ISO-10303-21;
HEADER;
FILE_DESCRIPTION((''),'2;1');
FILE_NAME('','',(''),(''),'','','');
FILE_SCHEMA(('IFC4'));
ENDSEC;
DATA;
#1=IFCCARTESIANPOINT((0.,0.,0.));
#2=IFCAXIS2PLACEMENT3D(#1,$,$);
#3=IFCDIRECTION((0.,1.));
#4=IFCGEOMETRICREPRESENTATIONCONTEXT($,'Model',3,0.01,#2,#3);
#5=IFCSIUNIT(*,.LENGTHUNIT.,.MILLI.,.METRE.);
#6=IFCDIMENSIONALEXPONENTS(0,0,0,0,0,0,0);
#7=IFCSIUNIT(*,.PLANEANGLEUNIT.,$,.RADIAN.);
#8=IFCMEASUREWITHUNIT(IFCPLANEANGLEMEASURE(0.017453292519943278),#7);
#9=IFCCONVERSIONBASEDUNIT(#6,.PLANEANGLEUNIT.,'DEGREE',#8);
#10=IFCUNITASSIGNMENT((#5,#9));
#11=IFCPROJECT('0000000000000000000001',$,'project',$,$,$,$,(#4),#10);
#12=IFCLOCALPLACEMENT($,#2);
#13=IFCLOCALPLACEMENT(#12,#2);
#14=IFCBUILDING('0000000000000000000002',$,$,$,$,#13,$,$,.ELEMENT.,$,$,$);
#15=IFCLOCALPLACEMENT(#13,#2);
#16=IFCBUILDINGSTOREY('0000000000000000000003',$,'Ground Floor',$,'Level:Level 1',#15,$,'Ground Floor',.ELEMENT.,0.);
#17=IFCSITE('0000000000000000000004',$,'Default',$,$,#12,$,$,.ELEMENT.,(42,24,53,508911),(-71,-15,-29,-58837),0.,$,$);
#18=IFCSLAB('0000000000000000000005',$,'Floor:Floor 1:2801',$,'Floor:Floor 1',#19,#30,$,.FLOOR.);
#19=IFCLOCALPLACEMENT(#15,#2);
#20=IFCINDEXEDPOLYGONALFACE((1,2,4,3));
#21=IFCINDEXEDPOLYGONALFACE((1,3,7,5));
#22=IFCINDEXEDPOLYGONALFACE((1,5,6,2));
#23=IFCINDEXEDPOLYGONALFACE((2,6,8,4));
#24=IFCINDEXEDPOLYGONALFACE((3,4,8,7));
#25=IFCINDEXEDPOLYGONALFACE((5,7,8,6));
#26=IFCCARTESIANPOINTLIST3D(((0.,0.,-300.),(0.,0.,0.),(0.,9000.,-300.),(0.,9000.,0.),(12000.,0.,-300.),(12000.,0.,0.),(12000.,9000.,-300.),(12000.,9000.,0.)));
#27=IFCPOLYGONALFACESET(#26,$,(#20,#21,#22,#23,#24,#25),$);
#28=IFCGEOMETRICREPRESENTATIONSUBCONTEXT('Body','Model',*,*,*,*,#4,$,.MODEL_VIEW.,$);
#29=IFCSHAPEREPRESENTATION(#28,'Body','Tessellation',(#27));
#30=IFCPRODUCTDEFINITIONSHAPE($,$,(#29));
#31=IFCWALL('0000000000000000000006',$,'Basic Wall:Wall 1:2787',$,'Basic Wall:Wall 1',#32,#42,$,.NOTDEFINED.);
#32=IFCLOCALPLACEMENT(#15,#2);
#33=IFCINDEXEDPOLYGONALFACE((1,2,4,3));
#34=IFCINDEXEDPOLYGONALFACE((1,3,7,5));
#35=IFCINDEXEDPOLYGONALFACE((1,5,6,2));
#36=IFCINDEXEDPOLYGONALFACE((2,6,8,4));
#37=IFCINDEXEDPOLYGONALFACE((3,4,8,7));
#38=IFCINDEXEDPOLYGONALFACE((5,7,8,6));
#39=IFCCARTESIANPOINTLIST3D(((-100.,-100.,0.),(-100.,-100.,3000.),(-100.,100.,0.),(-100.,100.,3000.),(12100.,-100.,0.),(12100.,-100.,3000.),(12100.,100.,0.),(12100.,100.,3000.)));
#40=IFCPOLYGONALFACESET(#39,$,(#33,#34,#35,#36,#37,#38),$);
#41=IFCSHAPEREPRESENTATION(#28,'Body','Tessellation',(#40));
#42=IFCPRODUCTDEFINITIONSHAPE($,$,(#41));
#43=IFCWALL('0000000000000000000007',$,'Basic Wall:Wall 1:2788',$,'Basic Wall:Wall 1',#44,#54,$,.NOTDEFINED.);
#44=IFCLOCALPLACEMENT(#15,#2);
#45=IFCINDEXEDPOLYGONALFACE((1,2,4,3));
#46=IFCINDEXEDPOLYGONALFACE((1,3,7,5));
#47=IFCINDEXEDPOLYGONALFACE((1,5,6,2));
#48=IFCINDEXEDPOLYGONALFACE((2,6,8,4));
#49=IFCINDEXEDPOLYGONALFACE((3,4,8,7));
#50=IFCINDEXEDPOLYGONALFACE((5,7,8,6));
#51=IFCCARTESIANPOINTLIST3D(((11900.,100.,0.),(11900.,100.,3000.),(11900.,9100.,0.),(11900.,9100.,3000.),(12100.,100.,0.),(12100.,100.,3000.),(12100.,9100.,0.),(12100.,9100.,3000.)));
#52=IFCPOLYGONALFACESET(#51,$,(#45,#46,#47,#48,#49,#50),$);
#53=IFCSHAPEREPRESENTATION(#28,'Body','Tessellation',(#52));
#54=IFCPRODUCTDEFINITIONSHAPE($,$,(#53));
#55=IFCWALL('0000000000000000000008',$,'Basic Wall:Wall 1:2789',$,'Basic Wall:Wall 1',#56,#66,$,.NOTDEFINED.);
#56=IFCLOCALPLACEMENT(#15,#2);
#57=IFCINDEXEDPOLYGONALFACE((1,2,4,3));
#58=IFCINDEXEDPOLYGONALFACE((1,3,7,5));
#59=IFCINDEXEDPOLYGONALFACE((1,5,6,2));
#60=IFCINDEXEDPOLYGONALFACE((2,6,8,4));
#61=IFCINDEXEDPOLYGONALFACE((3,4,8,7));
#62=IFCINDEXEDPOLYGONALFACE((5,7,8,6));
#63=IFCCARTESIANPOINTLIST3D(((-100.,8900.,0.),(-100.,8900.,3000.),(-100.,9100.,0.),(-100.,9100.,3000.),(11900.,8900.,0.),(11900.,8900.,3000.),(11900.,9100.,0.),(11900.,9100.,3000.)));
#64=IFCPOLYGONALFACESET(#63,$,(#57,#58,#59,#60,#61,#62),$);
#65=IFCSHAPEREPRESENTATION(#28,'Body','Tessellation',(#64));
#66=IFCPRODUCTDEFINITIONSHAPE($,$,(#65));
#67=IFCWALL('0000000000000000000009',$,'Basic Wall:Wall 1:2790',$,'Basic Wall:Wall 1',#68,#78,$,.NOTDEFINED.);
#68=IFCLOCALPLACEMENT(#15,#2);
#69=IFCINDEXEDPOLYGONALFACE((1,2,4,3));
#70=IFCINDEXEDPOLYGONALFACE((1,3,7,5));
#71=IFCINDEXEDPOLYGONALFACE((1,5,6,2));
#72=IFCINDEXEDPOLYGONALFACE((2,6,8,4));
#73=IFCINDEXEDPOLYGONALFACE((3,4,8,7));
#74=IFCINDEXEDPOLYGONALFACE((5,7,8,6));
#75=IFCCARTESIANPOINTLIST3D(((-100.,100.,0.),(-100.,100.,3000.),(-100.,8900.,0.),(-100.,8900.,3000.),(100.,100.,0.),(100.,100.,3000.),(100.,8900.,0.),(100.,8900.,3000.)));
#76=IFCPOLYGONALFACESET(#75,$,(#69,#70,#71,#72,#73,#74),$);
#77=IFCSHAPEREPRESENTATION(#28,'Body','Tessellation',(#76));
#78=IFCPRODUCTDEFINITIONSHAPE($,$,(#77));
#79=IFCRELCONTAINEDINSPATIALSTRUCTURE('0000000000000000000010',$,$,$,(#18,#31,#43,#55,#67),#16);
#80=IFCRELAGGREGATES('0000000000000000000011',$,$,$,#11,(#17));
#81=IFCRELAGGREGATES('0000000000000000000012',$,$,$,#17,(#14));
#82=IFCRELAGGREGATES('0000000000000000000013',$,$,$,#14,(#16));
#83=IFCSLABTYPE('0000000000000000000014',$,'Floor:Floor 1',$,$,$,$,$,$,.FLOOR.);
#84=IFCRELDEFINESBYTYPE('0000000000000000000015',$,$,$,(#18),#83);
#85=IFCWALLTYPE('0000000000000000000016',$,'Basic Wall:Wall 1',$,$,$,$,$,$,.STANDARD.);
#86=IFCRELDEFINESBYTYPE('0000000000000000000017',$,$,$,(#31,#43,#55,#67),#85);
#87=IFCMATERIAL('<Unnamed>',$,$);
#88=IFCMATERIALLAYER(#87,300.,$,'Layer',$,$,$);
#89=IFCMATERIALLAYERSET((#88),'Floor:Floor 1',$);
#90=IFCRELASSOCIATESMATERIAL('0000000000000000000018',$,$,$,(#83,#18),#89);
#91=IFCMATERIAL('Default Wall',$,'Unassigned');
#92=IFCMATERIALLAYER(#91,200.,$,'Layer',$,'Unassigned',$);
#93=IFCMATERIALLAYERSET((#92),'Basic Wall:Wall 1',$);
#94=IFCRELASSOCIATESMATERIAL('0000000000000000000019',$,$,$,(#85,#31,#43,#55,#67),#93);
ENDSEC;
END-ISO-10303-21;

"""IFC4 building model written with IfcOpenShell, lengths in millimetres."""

from ifc_helpers import new_model, entity, si_unit, converted_unit, direction, frame, frame_2d, origin, origin_2d_with_axis, place, context, subcontext, project, spatial, rectangle, extrude, material, layer, layer_set, layer_usage, type_object, element, save


model = new_model("IFC4")

# Units and contexts
model_context = context("Model", 3, precision=0.01, world=origin(), true_north=direction((0.0, 1.0)))
body_context = subcontext(model_context, "Body", "Model", "MODEL_VIEW")
ifc_project = project(units=[si_unit("LENGTHUNIT", "METRE", prefix="MILLI"), converted_unit("PLANEANGLEUNIT", "DEGREE", entity("IfcPlaneAngleMeasure", 0.017453292519943278), si_unit("PLANEANGLEUNIT", "RADIAN"), dimensions=[0, 0, 0, 0, 0, 0, 0])], contexts=[model_context])

# Site, building, storey
site_placement = place(None, origin())
site = spatial("IfcSite", under=ifc_project, at=site_placement, Name="Default", CompositionType="ELEMENT", RefLatitude=(42, 24, 53, 508911), RefLongitude=(-71, -15, -29, -58837), RefElevation=0.0)
building_placement = place(site_placement, origin())
building = spatial("IfcBuilding", under=site, at=building_placement, CompositionType="ELEMENT")
storey_placement = place(building_placement, origin())
storey = spatial("IfcBuildingStorey", under=building, at=storey_placement, Name="Ground Floor", ObjectType="Level:Level 1", LongName="Ground Floor", CompositionType="ELEMENT", Elevation=0.0)

# Slab
ifc_material_1 = material(Name="<Unnamed>")
ifc_layer_1 = layer(ifc_material_1, 300.0, Name="Layer")
ifc_layer_set_1 = layer_set([ifc_layer_1], Name="Floor:Floor 1")
ifc_layer_usage_1 = layer_usage(ifc_layer_set_1, "AXIS3", "POSITIVE", 0.0)
slab_type = type_object("IfcSlabType", Name="Floor:Floor 1", PredefinedType="FLOOR", material=ifc_layer_set_1)
slab_placement = place(storey_placement, origin())
element("IfcSlab", 1, at=slab_placement, inside=storey, type_object=slab_type, material=ifc_layer_usage_1, Name="Floor:Floor 1:2801", ObjectType="Floor:Floor 1", PredefinedType="FLOOR", context=body_context, shape_type="SweptSolid", body=[
    extrude(rectangle(XDim=9000.0, YDim=12000.0, at=origin_2d_with_axis()), frame((6000.0, 4500.0, 0.0), z_axis=(0.0, 0.0, -1.0), x_axis=(0.0, 1.0, 0.0)), (0.0, 0.0, 1.0), 300.0),
])

# Walls
ifc_material_2 = material(Name="Default Wall", Category="Unassigned")
ifc_layer_2 = layer(ifc_material_2, 200.0, Name="Layer", Category="Unassigned")
ifc_layer_set_2 = layer_set([ifc_layer_2], Name="Basic Wall:Wall 1")
ifc_layer_usage_2 = layer_usage(ifc_layer_set_2, "AXIS2", "NEGATIVE", 100.0)
wall_type = type_object("IfcWallType", Name="Basic Wall:Wall 1", PredefinedType="STANDARD", material=ifc_layer_set_2)
wall_1_placement = place(storey_placement, frame((-100.0, 0.0, 0.0)))
element("IfcWall", 2, at=wall_1_placement, inside=storey, type_object=wall_type, material=ifc_layer_usage_2, Name="Basic Wall:Wall 1:2787", ObjectType="Basic Wall:Wall 1", PredefinedType="NOTDEFINED", context=body_context, shape_type="SweptSolid", body=[
    extrude(rectangle(XDim=12200.0, YDim=200.0, at=frame_2d((6100.0, 0.0), x_axis=(-1.0, 0.0))), origin(), (0.0, 0.0, 1.0), 3000.0),
])
ifc_layer_usage_3 = layer_usage(ifc_layer_set_2, "AXIS2", "NEGATIVE", 100.0)
wall_2_placement = place(storey_placement, frame((12000.0, 100.0, 0.0), z_axis=(0.0, 0.0, 1.0), x_axis=(0.0, 1.0, 0.0)))
element("IfcWall", 3, at=wall_2_placement, inside=storey, type_object=wall_type, material=ifc_layer_usage_3, Name="Basic Wall:Wall 1:2788", ObjectType="Basic Wall:Wall 1", PredefinedType="NOTDEFINED", context=body_context, shape_type="SweptSolid", body=[
    extrude(rectangle(XDim=9000.0, YDim=200.0, at=frame_2d((4500.0, 0.0), x_axis=(-1.0, 0.0))), origin(), (0.0, 0.0, 1.0), 3000.0),
])
ifc_layer_usage_4 = layer_usage(ifc_layer_set_2, "AXIS2", "NEGATIVE", 100.0)
wall_3_placement = place(storey_placement, frame((11900.0, 9000.0, 0.0), z_axis=(0.0, 0.0, 1.0), x_axis=(-1.0, 0.0, 0.0)))
element("IfcWall", 4, at=wall_3_placement, inside=storey, type_object=wall_type, material=ifc_layer_usage_4, Name="Basic Wall:Wall 1:2789", ObjectType="Basic Wall:Wall 1", PredefinedType="NOTDEFINED", context=body_context, shape_type="SweptSolid", body=[
    extrude(rectangle(XDim=12000.0, YDim=200.0, at=frame_2d((6000.0, 0.0), x_axis=(-1.0, 0.0))), origin(), (0.0, 0.0, 1.0), 3000.0),
])
ifc_layer_usage_5 = layer_usage(ifc_layer_set_2, "AXIS2", "NEGATIVE", 100.0)
wall_4_placement = place(storey_placement, frame((0.0, 8900.0, 0.0), z_axis=(0.0, 0.0, 1.0), x_axis=(0.0, -1.0, 0.0)))
element("IfcWall", 5, at=wall_4_placement, inside=storey, type_object=wall_type, material=ifc_layer_usage_5, Name="Basic Wall:Wall 1:2790", ObjectType="Basic Wall:Wall 1", PredefinedType="NOTDEFINED", context=body_context, shape_type="SweptSolid", body=[
    extrude(rectangle(XDim=8800.0, YDim=200.0, at=frame_2d((4400.0, 0.0), x_axis=(-1.0, 0.0))), origin(), (0.0, 0.0, 1.0), 3000.0),
])

save(model, "model.ifc")
